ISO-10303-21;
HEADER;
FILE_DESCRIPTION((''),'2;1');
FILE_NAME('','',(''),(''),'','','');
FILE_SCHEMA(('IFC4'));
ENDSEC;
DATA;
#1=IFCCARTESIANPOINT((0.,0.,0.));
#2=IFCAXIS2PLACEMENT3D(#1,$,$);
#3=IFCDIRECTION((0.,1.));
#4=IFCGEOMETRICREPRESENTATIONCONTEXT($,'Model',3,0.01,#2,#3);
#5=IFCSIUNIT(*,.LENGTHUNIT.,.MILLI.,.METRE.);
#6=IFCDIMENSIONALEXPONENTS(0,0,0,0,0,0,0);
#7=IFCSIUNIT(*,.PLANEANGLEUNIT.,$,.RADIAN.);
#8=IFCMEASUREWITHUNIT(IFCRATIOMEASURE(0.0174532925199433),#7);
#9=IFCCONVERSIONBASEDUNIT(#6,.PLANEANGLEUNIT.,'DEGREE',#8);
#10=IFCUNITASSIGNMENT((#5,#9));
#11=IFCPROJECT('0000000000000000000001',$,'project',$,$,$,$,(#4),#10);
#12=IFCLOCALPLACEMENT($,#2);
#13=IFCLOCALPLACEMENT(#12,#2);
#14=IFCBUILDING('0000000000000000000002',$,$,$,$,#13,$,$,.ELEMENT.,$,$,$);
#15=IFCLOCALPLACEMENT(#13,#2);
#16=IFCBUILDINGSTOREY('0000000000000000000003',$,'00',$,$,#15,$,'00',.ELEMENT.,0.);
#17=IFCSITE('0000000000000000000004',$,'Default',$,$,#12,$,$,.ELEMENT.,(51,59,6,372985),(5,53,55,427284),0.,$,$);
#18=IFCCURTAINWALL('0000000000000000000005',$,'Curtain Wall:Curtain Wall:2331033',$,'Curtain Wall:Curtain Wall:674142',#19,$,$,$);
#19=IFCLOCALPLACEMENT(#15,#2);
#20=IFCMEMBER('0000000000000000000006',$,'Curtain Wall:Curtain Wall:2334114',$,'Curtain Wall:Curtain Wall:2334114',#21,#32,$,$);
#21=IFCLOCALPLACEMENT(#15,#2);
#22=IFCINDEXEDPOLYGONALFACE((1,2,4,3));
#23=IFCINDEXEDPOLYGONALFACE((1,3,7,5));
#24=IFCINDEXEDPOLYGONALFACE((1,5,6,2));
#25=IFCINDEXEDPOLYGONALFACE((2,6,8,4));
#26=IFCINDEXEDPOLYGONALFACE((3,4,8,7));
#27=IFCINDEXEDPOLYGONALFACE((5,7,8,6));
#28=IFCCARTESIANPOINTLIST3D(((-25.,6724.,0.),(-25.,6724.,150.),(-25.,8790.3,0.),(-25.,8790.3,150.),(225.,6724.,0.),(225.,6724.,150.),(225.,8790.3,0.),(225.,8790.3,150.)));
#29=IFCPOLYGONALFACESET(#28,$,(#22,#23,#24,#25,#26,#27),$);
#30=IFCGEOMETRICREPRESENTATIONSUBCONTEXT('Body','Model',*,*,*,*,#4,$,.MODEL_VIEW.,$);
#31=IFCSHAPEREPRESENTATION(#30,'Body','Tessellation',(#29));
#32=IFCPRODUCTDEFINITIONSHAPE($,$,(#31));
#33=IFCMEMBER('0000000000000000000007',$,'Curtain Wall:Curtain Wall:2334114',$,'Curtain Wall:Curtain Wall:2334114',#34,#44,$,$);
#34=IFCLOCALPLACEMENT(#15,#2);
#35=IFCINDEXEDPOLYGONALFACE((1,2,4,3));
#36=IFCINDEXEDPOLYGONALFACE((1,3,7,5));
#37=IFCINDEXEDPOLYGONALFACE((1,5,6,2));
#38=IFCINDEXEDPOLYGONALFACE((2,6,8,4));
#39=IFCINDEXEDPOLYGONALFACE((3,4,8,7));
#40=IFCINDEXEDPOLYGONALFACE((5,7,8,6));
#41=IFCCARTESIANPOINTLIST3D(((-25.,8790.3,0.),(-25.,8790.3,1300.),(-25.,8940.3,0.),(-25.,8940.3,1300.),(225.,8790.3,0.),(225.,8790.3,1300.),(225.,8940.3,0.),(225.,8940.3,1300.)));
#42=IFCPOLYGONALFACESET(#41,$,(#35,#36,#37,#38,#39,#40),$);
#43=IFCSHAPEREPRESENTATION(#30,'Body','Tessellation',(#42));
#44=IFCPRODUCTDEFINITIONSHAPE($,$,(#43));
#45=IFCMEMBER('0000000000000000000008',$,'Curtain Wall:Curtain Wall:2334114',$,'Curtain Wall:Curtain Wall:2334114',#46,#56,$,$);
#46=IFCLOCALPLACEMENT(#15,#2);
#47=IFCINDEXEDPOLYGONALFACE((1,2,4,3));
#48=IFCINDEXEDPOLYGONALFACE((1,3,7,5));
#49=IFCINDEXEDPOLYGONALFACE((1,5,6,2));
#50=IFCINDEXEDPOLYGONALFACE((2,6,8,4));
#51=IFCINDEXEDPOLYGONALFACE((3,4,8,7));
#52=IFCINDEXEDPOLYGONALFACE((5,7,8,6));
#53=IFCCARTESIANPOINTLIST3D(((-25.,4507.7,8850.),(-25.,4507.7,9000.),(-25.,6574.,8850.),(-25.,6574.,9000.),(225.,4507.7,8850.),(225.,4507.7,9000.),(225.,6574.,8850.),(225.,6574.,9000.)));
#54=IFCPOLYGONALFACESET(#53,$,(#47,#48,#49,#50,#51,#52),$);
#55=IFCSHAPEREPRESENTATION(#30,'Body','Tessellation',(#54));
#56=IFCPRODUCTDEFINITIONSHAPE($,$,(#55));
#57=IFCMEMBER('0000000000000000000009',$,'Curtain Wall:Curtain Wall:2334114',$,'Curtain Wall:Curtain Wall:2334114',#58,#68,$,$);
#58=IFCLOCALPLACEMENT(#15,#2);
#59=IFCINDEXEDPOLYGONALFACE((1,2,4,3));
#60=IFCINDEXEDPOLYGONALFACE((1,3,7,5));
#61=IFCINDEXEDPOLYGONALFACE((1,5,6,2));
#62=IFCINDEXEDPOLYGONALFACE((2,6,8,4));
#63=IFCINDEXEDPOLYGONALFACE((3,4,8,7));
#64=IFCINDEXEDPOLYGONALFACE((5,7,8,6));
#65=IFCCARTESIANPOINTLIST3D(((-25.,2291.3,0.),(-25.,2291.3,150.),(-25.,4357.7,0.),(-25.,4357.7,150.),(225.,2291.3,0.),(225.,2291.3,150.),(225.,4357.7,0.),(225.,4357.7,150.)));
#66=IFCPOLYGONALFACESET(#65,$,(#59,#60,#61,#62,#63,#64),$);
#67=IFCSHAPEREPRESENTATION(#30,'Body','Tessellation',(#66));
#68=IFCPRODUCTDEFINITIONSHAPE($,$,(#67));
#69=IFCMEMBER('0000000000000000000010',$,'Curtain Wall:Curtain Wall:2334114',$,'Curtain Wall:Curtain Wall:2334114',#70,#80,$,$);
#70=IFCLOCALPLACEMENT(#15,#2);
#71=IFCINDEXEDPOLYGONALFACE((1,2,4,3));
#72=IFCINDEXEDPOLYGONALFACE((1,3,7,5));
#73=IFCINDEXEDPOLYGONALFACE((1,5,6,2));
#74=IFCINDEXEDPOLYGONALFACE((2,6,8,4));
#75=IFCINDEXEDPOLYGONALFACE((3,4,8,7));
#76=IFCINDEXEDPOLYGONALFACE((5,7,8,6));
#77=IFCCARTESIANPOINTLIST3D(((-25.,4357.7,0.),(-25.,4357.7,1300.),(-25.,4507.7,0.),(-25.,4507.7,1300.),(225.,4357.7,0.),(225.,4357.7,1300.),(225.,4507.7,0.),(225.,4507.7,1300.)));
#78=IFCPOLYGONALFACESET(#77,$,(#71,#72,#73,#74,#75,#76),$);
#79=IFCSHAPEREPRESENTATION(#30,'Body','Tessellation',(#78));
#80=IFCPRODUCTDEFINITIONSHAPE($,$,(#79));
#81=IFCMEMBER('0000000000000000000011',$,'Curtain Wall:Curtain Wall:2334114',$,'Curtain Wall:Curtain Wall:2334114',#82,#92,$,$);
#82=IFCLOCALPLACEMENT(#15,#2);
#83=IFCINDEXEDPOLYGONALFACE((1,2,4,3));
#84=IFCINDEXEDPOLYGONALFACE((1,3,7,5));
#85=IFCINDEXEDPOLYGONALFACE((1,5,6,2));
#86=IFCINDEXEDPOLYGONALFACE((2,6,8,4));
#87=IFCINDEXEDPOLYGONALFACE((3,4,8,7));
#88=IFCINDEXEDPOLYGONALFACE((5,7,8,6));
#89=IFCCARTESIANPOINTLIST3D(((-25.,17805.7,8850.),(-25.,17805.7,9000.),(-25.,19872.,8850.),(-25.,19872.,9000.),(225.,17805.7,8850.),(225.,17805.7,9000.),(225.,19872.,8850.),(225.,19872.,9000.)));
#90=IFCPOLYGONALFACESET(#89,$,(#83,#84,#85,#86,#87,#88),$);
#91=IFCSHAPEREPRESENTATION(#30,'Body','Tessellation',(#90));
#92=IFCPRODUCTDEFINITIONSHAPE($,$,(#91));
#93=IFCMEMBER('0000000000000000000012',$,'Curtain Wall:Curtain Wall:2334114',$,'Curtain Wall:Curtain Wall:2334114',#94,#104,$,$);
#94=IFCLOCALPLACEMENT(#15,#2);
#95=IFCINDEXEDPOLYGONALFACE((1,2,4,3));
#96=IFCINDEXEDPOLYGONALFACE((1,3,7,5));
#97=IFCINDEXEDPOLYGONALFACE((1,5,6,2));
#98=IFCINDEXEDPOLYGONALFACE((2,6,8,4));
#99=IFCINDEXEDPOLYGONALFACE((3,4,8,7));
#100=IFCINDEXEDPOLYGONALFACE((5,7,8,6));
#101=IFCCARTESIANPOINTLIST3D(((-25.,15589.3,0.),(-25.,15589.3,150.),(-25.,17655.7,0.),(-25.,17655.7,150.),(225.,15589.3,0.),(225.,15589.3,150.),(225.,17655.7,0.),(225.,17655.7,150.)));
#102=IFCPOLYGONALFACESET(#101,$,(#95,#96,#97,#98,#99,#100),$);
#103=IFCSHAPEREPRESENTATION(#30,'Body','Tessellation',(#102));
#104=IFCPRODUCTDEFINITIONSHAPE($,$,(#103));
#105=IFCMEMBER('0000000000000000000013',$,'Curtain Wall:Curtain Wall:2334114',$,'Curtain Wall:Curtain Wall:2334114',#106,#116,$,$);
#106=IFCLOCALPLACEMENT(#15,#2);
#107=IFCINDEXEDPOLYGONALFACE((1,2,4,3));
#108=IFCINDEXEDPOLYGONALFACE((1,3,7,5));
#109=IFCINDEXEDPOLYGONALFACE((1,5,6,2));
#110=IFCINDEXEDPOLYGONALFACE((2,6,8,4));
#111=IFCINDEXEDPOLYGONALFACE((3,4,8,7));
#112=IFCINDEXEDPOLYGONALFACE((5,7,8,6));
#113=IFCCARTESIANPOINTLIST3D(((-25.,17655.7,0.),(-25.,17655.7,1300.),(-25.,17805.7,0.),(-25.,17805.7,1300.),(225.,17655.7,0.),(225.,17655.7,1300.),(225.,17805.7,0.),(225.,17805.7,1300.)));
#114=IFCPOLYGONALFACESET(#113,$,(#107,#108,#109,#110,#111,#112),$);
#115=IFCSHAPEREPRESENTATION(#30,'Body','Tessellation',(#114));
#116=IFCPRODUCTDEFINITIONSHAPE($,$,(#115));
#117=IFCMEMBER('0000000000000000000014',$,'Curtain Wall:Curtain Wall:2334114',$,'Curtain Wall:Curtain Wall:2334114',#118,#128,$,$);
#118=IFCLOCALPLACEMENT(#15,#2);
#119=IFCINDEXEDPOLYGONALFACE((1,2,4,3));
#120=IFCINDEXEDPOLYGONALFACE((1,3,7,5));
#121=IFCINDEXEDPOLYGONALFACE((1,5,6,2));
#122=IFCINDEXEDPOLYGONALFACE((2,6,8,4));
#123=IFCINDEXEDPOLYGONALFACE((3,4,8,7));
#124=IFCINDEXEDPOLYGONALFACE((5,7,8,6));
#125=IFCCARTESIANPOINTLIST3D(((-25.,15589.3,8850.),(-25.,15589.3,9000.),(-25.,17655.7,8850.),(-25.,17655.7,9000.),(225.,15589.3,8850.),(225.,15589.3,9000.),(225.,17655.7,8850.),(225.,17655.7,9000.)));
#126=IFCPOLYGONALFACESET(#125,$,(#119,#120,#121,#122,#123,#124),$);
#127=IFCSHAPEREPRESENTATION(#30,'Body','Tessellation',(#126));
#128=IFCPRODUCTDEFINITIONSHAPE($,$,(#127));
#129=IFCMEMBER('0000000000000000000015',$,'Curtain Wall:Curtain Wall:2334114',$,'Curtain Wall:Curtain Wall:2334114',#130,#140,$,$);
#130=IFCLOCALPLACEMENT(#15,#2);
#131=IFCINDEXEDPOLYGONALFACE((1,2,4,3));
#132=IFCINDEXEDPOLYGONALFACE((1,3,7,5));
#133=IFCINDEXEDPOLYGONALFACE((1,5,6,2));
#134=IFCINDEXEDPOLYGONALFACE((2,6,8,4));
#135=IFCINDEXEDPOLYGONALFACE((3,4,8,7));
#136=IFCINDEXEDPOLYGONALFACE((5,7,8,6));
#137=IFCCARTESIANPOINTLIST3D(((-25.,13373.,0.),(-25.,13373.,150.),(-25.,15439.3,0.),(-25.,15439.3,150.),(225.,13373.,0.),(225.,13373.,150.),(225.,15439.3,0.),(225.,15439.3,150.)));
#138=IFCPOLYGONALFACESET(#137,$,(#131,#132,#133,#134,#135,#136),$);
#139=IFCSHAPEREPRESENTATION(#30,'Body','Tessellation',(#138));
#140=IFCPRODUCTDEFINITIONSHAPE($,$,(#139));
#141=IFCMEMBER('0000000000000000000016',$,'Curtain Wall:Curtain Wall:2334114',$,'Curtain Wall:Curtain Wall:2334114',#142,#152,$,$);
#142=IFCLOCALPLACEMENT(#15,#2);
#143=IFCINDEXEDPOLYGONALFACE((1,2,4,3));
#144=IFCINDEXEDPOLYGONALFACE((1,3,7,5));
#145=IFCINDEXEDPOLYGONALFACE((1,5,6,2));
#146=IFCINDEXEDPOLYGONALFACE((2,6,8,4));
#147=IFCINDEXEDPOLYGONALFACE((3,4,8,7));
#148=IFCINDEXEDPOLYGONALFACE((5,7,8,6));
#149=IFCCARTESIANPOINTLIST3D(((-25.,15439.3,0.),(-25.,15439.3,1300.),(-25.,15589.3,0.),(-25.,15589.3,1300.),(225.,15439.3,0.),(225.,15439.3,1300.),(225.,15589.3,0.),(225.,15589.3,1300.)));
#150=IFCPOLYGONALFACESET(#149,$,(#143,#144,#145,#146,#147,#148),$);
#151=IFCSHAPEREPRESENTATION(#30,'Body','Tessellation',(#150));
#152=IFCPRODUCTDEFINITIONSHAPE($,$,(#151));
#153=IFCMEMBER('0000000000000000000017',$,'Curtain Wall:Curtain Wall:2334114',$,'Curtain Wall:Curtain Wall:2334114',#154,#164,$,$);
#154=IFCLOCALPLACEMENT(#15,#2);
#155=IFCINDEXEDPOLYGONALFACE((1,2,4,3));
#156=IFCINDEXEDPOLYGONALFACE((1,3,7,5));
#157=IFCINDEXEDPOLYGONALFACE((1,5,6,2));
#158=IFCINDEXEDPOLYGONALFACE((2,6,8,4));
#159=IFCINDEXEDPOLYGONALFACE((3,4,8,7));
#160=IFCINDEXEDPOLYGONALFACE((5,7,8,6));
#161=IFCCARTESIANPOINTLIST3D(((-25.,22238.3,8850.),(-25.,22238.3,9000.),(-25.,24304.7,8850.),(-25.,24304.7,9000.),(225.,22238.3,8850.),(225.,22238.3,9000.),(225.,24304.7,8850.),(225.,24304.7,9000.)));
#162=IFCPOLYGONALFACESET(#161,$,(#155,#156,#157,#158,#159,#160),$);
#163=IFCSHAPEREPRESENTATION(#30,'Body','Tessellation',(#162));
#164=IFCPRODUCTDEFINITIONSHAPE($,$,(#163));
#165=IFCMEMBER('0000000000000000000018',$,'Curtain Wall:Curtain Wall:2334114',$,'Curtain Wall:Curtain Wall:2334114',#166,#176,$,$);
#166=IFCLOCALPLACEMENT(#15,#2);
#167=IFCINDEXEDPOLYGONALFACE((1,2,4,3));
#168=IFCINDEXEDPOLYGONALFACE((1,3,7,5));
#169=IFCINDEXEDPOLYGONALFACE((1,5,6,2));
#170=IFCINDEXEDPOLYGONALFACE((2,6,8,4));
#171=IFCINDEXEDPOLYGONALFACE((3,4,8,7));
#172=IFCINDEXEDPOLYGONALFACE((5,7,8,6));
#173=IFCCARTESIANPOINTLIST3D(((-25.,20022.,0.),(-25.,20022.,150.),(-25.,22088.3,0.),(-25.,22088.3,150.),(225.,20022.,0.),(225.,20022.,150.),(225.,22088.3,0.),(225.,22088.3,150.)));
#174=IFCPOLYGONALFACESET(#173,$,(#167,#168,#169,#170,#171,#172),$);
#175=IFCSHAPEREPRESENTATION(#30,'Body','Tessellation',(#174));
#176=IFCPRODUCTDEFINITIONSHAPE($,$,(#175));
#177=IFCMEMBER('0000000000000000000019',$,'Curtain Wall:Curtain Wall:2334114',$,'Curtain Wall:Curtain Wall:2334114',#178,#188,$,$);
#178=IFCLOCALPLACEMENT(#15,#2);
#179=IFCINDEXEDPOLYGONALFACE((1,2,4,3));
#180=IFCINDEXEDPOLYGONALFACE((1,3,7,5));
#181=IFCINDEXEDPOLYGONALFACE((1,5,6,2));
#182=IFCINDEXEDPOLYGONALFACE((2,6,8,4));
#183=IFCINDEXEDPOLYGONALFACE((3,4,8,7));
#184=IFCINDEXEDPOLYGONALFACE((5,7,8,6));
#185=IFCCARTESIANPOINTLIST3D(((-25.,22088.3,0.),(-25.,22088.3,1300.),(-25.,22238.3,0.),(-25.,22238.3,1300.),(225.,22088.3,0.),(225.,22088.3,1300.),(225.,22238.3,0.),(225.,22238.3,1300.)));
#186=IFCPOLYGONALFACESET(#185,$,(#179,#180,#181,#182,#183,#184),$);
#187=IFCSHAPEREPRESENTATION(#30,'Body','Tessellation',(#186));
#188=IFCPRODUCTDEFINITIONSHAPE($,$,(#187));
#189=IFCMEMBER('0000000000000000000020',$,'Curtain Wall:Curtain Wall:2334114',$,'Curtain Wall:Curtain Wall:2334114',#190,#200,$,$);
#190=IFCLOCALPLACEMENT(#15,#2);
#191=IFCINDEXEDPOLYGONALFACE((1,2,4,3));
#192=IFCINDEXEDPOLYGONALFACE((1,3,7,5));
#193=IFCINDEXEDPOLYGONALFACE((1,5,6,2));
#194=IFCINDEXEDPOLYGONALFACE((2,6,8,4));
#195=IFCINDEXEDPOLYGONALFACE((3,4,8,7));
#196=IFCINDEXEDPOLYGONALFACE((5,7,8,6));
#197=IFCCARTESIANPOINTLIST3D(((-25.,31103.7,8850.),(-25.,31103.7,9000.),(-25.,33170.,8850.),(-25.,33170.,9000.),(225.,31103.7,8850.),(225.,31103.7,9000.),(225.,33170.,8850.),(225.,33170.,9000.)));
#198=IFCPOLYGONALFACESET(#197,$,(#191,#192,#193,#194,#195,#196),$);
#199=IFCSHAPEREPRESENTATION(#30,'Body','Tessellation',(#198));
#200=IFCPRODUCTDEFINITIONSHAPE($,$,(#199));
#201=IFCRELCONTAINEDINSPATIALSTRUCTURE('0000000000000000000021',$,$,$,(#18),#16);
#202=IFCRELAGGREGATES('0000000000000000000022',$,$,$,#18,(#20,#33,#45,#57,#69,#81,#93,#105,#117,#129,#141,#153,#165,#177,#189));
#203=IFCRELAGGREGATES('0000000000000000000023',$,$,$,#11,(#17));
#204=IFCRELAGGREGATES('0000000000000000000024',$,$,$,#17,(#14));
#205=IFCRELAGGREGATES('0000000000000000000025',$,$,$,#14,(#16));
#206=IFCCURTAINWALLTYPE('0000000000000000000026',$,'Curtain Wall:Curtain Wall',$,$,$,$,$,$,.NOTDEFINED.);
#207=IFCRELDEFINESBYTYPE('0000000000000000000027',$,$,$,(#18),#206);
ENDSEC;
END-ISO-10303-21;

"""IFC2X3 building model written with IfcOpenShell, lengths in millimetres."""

from ifc_helpers import new_model, entity, si_unit, converted_unit, direction, frame, frame_2d, origin, origin_2d_with_axis, place, context, subcontext, project, spatial, rectangle, extrude, type_object, element, aggregate, save


model = new_model("IFC2X3")

# Units and contexts
model_context = context("Model", 3, precision=0.01, world=origin(), true_north=direction((0.0, 1.0)))
body_context = subcontext(model_context, "Body", "Model", "MODEL_VIEW")
ifc_project = project(units=[si_unit("LENGTHUNIT", "METRE", prefix="MILLI"), converted_unit("PLANEANGLEUNIT", "DEGREE", entity("IfcRatioMeasure", 0.0174532925199433), si_unit("PLANEANGLEUNIT", "RADIAN"), dimensions=[0, 0, 0, 0, 0, 0, 0])], contexts=[model_context])

# Site, building, storey
site_placement = place(None, origin())
site = spatial("IfcSite", under=ifc_project, at=site_placement, Name="Default", CompositionType="ELEMENT", RefLatitude=(51, 59, 6, 372985), RefLongitude=(5, 53, 55, 427284), RefElevation=0.0)
building_placement = place(site_placement, origin())
building = spatial("IfcBuilding", under=site, at=building_placement, CompositionType="ELEMENT")
storey_placement = place(building_placement, origin())
storey = spatial("IfcBuildingStorey", under=building, at=storey_placement, Name="00", LongName="00", CompositionType="ELEMENT", Elevation=0.0)

# Curtain wall, members
curtain_wall_type = type_object("IfcCurtainWallType", Name="Curtain Wall:Curtain Wall", PredefinedType="NOTDEFINED")
curtain_wall_placement = place(storey_placement, origin())
curtain_wall = element("IfcCurtainWall", 1, at=curtain_wall_placement, inside=storey, type_object=curtain_wall_type, Name="Curtain Wall:Curtain Wall:2331033", ObjectType="Curtain Wall:Curtain Wall:674142")
member_1_placement = place(curtain_wall_placement, origin())
member_1 = element("IfcMember", 2, at=member_1_placement, Name="Curtain Wall:Curtain Wall:2334114", ObjectType="Curtain Wall:Curtain Wall:2334114", context=body_context, shape_type="SweptSolid", body=[
    extrude(rectangle(XDim=150.0, YDim=250.0, at=origin_2d_with_axis()), frame((100.0, 8790.3, 75.0), z_axis=(0.0, -1.0, 0.0), x_axis=(0.0, 0.0, -1.0)), (0.0, 0.0, 1.0), 2066.3),
])
member_2_placement = place(curtain_wall_placement, origin())
member_2 = element("IfcMember", 3, at=member_2_placement, Name="Curtain Wall:Curtain Wall:2334114", ObjectType="Curtain Wall:Curtain Wall:2334114", context=body_context, shape_type="SweptSolid", body=[
    extrude(rectangle(XDim=250.0, YDim=150.0, at=frame_2d((0.0, 0.0), x_axis=(1.0, 0.0))), frame((100.0, 8865.3, 0.0), z_axis=(0.0, 0.0, 1.0), x_axis=(-1.0, 0.0, 0.0)), (0.0, 0.0, 1.0), 1300.0),
])
member_3_placement = place(curtain_wall_placement, origin())
member_3 = element("IfcMember", 4, at=member_3_placement, Name="Curtain Wall:Curtain Wall:2334114", ObjectType="Curtain Wall:Curtain Wall:2334114", context=body_context, shape_type="SweptSolid", body=[
    extrude(rectangle(XDim=150.0, YDim=250.0, at=origin_2d_with_axis()), frame((100.0, 4507.7, 8925.0), z_axis=(0.0, 1.0, 0.0), x_axis=(0.0, 0.0, -1.0)), (0.0, 0.0, 1.0), 2066.3),
])
member_4_placement = place(curtain_wall_placement, origin())
member_4 = element("IfcMember", 5, at=member_4_placement, Name="Curtain Wall:Curtain Wall:2334114", ObjectType="Curtain Wall:Curtain Wall:2334114", context=body_context, shape_type="SweptSolid", body=[
    extrude(rectangle(XDim=150.0, YDim=250.0, at=origin_2d_with_axis()), frame((100.0, 4357.7, 75.0), z_axis=(0.0, -1.0, 0.0), x_axis=(0.0, 0.0, -1.0)), (0.0, 0.0, 1.0), 2066.3),
])
member_5_placement = place(curtain_wall_placement, origin())
member_5 = element("IfcMember", 6, at=member_5_placement, Name="Curtain Wall:Curtain Wall:2334114", ObjectType="Curtain Wall:Curtain Wall:2334114", context=body_context, shape_type="SweptSolid", body=[
    extrude(rectangle(XDim=250.0, YDim=150.0, at=frame_2d((0.0, 0.0), x_axis=(1.0, 0.0))), frame((100.0, 4432.7, 0.0), z_axis=(0.0, 0.0, 1.0), x_axis=(-1.0, 0.0, 0.0)), (0.0, 0.0, 1.0), 1300.0),
])
member_6_placement = place(curtain_wall_placement, origin())
member_6 = element("IfcMember", 7, at=member_6_placement, Name="Curtain Wall:Curtain Wall:2334114", ObjectType="Curtain Wall:Curtain Wall:2334114", context=body_context, shape_type="SweptSolid", body=[
    extrude(rectangle(XDim=150.0, YDim=250.0, at=origin_2d_with_axis()), frame((100.0, 17805.7, 8925.0), z_axis=(0.0, 1.0, 0.0), x_axis=(0.0, 0.0, -1.0)), (0.0, 0.0, 1.0), 2066.3),
])
member_7_placement = place(curtain_wall_placement, origin())
member_7 = element("IfcMember", 8, at=member_7_placement, Name="Curtain Wall:Curtain Wall:2334114", ObjectType="Curtain Wall:Curtain Wall:2334114", context=body_context, shape_type="SweptSolid", body=[
    extrude(rectangle(XDim=150.0, YDim=250.0, at=origin_2d_with_axis()), frame((100.0, 17655.7, 75.0), z_axis=(0.0, -1.0, 0.0), x_axis=(0.0, 0.0, -1.0)), (0.0, 0.0, 1.0), 2066.3),
])
member_8_placement = place(curtain_wall_placement, origin())
member_8 = element("IfcMember", 9, at=member_8_placement, Name="Curtain Wall:Curtain Wall:2334114", ObjectType="Curtain Wall:Curtain Wall:2334114", context=body_context, shape_type="SweptSolid", body=[
    extrude(rectangle(XDim=250.0, YDim=150.0, at=frame_2d((0.0, 0.0), x_axis=(1.0, 0.0))), frame((100.0, 17730.7, 0.0), z_axis=(0.0, 0.0, 1.0), x_axis=(-1.0, 0.0, 0.0)), (0.0, 0.0, 1.0), 1300.0),
])
member_9_placement = place(curtain_wall_placement, origin())
member_9 = element("IfcMember", 10, at=member_9_placement, Name="Curtain Wall:Curtain Wall:2334114", ObjectType="Curtain Wall:Curtain Wall:2334114", context=body_context, shape_type="SweptSolid", body=[
    extrude(rectangle(XDim=150.0, YDim=250.0, at=origin_2d_with_axis()), frame((100.0, 15589.3, 8925.0), z_axis=(0.0, 1.0, 0.0), x_axis=(0.0, 0.0, -1.0)), (0.0, 0.0, 1.0), 2066.3),
])
member_10_placement = place(curtain_wall_placement, origin())
member_10 = element("IfcMember", 11, at=member_10_placement, Name="Curtain Wall:Curtain Wall:2334114", ObjectType="Curtain Wall:Curtain Wall:2334114", context=body_context, shape_type="SweptSolid", body=[
    extrude(rectangle(XDim=150.0, YDim=250.0, at=origin_2d_with_axis()), frame((100.0, 15439.3, 75.0), z_axis=(0.0, -1.0, 0.0), x_axis=(0.0, 0.0, -1.0)), (0.0, 0.0, 1.0), 2066.3),
])
member_11_placement = place(curtain_wall_placement, origin())
member_11 = element("IfcMember", 12, at=member_11_placement, Name="Curtain Wall:Curtain Wall:2334114", ObjectType="Curtain Wall:Curtain Wall:2334114", context=body_context, shape_type="SweptSolid", body=[
    extrude(rectangle(XDim=250.0, YDim=150.0, at=frame_2d((0.0, 0.0), x_axis=(1.0, 0.0))), frame((100.0, 15514.3, 0.0), z_axis=(0.0, 0.0, 1.0), x_axis=(-1.0, 0.0, 0.0)), (0.0, 0.0, 1.0), 1300.0),
])
member_12_placement = place(curtain_wall_placement, origin())
member_12 = element("IfcMember", 13, at=member_12_placement, Name="Curtain Wall:Curtain Wall:2334114", ObjectType="Curtain Wall:Curtain Wall:2334114", context=body_context, shape_type="SweptSolid", body=[
    extrude(rectangle(XDim=150.0, YDim=250.0, at=origin_2d_with_axis()), frame((100.0, 22238.3, 8925.0), z_axis=(0.0, 1.0, 0.0), x_axis=(0.0, 0.0, -1.0)), (0.0, 0.0, 1.0), 2066.3),
])
member_13_placement = place(curtain_wall_placement, origin())
member_13 = element("IfcMember", 14, at=member_13_placement, Name="Curtain Wall:Curtain Wall:2334114", ObjectType="Curtain Wall:Curtain Wall:2334114", context=body_context, shape_type="SweptSolid", body=[
    extrude(rectangle(XDim=150.0, YDim=250.0, at=origin_2d_with_axis()), frame((100.0, 22088.3, 75.0), z_axis=(0.0, -1.0, 0.0), x_axis=(0.0, 0.0, -1.0)), (0.0, 0.0, 1.0), 2066.3),
])
member_14_placement = place(curtain_wall_placement, origin())
member_14 = element("IfcMember", 15, at=member_14_placement, Name="Curtain Wall:Curtain Wall:2334114", ObjectType="Curtain Wall:Curtain Wall:2334114", context=body_context, shape_type="SweptSolid", body=[
    extrude(rectangle(XDim=250.0, YDim=150.0, at=origin_2d_with_axis()), frame((100.0, 22163.3, 0.0), z_axis=(0.0, 0.0, 1.0), x_axis=(-1.0, 0.0, 0.0)), (0.0, 0.0, 1.0), 1300.0),
])
member_15_placement = place(curtain_wall_placement, origin())
member_15 = element("IfcMember", 16, at=member_15_placement, Name="Curtain Wall:Curtain Wall:2334114", ObjectType="Curtain Wall:Curtain Wall:2334114", context=body_context, shape_type="SweptSolid", body=[
    extrude(rectangle(XDim=150.0, YDim=250.0, at=origin_2d_with_axis()), frame((100.0, 31103.7, 8925.0), z_axis=(0.0, 1.0, 0.0), x_axis=(0.0, 0.0, -1.0)), (0.0, 0.0, 1.0), 2066.3),
])
aggregate(curtain_wall, [member_1, member_2, member_3, member_4, member_5, member_6, member_7, member_8, member_9, member_10, member_11, member_12, member_13, member_14, member_15])

save(model, "model.ifc")
